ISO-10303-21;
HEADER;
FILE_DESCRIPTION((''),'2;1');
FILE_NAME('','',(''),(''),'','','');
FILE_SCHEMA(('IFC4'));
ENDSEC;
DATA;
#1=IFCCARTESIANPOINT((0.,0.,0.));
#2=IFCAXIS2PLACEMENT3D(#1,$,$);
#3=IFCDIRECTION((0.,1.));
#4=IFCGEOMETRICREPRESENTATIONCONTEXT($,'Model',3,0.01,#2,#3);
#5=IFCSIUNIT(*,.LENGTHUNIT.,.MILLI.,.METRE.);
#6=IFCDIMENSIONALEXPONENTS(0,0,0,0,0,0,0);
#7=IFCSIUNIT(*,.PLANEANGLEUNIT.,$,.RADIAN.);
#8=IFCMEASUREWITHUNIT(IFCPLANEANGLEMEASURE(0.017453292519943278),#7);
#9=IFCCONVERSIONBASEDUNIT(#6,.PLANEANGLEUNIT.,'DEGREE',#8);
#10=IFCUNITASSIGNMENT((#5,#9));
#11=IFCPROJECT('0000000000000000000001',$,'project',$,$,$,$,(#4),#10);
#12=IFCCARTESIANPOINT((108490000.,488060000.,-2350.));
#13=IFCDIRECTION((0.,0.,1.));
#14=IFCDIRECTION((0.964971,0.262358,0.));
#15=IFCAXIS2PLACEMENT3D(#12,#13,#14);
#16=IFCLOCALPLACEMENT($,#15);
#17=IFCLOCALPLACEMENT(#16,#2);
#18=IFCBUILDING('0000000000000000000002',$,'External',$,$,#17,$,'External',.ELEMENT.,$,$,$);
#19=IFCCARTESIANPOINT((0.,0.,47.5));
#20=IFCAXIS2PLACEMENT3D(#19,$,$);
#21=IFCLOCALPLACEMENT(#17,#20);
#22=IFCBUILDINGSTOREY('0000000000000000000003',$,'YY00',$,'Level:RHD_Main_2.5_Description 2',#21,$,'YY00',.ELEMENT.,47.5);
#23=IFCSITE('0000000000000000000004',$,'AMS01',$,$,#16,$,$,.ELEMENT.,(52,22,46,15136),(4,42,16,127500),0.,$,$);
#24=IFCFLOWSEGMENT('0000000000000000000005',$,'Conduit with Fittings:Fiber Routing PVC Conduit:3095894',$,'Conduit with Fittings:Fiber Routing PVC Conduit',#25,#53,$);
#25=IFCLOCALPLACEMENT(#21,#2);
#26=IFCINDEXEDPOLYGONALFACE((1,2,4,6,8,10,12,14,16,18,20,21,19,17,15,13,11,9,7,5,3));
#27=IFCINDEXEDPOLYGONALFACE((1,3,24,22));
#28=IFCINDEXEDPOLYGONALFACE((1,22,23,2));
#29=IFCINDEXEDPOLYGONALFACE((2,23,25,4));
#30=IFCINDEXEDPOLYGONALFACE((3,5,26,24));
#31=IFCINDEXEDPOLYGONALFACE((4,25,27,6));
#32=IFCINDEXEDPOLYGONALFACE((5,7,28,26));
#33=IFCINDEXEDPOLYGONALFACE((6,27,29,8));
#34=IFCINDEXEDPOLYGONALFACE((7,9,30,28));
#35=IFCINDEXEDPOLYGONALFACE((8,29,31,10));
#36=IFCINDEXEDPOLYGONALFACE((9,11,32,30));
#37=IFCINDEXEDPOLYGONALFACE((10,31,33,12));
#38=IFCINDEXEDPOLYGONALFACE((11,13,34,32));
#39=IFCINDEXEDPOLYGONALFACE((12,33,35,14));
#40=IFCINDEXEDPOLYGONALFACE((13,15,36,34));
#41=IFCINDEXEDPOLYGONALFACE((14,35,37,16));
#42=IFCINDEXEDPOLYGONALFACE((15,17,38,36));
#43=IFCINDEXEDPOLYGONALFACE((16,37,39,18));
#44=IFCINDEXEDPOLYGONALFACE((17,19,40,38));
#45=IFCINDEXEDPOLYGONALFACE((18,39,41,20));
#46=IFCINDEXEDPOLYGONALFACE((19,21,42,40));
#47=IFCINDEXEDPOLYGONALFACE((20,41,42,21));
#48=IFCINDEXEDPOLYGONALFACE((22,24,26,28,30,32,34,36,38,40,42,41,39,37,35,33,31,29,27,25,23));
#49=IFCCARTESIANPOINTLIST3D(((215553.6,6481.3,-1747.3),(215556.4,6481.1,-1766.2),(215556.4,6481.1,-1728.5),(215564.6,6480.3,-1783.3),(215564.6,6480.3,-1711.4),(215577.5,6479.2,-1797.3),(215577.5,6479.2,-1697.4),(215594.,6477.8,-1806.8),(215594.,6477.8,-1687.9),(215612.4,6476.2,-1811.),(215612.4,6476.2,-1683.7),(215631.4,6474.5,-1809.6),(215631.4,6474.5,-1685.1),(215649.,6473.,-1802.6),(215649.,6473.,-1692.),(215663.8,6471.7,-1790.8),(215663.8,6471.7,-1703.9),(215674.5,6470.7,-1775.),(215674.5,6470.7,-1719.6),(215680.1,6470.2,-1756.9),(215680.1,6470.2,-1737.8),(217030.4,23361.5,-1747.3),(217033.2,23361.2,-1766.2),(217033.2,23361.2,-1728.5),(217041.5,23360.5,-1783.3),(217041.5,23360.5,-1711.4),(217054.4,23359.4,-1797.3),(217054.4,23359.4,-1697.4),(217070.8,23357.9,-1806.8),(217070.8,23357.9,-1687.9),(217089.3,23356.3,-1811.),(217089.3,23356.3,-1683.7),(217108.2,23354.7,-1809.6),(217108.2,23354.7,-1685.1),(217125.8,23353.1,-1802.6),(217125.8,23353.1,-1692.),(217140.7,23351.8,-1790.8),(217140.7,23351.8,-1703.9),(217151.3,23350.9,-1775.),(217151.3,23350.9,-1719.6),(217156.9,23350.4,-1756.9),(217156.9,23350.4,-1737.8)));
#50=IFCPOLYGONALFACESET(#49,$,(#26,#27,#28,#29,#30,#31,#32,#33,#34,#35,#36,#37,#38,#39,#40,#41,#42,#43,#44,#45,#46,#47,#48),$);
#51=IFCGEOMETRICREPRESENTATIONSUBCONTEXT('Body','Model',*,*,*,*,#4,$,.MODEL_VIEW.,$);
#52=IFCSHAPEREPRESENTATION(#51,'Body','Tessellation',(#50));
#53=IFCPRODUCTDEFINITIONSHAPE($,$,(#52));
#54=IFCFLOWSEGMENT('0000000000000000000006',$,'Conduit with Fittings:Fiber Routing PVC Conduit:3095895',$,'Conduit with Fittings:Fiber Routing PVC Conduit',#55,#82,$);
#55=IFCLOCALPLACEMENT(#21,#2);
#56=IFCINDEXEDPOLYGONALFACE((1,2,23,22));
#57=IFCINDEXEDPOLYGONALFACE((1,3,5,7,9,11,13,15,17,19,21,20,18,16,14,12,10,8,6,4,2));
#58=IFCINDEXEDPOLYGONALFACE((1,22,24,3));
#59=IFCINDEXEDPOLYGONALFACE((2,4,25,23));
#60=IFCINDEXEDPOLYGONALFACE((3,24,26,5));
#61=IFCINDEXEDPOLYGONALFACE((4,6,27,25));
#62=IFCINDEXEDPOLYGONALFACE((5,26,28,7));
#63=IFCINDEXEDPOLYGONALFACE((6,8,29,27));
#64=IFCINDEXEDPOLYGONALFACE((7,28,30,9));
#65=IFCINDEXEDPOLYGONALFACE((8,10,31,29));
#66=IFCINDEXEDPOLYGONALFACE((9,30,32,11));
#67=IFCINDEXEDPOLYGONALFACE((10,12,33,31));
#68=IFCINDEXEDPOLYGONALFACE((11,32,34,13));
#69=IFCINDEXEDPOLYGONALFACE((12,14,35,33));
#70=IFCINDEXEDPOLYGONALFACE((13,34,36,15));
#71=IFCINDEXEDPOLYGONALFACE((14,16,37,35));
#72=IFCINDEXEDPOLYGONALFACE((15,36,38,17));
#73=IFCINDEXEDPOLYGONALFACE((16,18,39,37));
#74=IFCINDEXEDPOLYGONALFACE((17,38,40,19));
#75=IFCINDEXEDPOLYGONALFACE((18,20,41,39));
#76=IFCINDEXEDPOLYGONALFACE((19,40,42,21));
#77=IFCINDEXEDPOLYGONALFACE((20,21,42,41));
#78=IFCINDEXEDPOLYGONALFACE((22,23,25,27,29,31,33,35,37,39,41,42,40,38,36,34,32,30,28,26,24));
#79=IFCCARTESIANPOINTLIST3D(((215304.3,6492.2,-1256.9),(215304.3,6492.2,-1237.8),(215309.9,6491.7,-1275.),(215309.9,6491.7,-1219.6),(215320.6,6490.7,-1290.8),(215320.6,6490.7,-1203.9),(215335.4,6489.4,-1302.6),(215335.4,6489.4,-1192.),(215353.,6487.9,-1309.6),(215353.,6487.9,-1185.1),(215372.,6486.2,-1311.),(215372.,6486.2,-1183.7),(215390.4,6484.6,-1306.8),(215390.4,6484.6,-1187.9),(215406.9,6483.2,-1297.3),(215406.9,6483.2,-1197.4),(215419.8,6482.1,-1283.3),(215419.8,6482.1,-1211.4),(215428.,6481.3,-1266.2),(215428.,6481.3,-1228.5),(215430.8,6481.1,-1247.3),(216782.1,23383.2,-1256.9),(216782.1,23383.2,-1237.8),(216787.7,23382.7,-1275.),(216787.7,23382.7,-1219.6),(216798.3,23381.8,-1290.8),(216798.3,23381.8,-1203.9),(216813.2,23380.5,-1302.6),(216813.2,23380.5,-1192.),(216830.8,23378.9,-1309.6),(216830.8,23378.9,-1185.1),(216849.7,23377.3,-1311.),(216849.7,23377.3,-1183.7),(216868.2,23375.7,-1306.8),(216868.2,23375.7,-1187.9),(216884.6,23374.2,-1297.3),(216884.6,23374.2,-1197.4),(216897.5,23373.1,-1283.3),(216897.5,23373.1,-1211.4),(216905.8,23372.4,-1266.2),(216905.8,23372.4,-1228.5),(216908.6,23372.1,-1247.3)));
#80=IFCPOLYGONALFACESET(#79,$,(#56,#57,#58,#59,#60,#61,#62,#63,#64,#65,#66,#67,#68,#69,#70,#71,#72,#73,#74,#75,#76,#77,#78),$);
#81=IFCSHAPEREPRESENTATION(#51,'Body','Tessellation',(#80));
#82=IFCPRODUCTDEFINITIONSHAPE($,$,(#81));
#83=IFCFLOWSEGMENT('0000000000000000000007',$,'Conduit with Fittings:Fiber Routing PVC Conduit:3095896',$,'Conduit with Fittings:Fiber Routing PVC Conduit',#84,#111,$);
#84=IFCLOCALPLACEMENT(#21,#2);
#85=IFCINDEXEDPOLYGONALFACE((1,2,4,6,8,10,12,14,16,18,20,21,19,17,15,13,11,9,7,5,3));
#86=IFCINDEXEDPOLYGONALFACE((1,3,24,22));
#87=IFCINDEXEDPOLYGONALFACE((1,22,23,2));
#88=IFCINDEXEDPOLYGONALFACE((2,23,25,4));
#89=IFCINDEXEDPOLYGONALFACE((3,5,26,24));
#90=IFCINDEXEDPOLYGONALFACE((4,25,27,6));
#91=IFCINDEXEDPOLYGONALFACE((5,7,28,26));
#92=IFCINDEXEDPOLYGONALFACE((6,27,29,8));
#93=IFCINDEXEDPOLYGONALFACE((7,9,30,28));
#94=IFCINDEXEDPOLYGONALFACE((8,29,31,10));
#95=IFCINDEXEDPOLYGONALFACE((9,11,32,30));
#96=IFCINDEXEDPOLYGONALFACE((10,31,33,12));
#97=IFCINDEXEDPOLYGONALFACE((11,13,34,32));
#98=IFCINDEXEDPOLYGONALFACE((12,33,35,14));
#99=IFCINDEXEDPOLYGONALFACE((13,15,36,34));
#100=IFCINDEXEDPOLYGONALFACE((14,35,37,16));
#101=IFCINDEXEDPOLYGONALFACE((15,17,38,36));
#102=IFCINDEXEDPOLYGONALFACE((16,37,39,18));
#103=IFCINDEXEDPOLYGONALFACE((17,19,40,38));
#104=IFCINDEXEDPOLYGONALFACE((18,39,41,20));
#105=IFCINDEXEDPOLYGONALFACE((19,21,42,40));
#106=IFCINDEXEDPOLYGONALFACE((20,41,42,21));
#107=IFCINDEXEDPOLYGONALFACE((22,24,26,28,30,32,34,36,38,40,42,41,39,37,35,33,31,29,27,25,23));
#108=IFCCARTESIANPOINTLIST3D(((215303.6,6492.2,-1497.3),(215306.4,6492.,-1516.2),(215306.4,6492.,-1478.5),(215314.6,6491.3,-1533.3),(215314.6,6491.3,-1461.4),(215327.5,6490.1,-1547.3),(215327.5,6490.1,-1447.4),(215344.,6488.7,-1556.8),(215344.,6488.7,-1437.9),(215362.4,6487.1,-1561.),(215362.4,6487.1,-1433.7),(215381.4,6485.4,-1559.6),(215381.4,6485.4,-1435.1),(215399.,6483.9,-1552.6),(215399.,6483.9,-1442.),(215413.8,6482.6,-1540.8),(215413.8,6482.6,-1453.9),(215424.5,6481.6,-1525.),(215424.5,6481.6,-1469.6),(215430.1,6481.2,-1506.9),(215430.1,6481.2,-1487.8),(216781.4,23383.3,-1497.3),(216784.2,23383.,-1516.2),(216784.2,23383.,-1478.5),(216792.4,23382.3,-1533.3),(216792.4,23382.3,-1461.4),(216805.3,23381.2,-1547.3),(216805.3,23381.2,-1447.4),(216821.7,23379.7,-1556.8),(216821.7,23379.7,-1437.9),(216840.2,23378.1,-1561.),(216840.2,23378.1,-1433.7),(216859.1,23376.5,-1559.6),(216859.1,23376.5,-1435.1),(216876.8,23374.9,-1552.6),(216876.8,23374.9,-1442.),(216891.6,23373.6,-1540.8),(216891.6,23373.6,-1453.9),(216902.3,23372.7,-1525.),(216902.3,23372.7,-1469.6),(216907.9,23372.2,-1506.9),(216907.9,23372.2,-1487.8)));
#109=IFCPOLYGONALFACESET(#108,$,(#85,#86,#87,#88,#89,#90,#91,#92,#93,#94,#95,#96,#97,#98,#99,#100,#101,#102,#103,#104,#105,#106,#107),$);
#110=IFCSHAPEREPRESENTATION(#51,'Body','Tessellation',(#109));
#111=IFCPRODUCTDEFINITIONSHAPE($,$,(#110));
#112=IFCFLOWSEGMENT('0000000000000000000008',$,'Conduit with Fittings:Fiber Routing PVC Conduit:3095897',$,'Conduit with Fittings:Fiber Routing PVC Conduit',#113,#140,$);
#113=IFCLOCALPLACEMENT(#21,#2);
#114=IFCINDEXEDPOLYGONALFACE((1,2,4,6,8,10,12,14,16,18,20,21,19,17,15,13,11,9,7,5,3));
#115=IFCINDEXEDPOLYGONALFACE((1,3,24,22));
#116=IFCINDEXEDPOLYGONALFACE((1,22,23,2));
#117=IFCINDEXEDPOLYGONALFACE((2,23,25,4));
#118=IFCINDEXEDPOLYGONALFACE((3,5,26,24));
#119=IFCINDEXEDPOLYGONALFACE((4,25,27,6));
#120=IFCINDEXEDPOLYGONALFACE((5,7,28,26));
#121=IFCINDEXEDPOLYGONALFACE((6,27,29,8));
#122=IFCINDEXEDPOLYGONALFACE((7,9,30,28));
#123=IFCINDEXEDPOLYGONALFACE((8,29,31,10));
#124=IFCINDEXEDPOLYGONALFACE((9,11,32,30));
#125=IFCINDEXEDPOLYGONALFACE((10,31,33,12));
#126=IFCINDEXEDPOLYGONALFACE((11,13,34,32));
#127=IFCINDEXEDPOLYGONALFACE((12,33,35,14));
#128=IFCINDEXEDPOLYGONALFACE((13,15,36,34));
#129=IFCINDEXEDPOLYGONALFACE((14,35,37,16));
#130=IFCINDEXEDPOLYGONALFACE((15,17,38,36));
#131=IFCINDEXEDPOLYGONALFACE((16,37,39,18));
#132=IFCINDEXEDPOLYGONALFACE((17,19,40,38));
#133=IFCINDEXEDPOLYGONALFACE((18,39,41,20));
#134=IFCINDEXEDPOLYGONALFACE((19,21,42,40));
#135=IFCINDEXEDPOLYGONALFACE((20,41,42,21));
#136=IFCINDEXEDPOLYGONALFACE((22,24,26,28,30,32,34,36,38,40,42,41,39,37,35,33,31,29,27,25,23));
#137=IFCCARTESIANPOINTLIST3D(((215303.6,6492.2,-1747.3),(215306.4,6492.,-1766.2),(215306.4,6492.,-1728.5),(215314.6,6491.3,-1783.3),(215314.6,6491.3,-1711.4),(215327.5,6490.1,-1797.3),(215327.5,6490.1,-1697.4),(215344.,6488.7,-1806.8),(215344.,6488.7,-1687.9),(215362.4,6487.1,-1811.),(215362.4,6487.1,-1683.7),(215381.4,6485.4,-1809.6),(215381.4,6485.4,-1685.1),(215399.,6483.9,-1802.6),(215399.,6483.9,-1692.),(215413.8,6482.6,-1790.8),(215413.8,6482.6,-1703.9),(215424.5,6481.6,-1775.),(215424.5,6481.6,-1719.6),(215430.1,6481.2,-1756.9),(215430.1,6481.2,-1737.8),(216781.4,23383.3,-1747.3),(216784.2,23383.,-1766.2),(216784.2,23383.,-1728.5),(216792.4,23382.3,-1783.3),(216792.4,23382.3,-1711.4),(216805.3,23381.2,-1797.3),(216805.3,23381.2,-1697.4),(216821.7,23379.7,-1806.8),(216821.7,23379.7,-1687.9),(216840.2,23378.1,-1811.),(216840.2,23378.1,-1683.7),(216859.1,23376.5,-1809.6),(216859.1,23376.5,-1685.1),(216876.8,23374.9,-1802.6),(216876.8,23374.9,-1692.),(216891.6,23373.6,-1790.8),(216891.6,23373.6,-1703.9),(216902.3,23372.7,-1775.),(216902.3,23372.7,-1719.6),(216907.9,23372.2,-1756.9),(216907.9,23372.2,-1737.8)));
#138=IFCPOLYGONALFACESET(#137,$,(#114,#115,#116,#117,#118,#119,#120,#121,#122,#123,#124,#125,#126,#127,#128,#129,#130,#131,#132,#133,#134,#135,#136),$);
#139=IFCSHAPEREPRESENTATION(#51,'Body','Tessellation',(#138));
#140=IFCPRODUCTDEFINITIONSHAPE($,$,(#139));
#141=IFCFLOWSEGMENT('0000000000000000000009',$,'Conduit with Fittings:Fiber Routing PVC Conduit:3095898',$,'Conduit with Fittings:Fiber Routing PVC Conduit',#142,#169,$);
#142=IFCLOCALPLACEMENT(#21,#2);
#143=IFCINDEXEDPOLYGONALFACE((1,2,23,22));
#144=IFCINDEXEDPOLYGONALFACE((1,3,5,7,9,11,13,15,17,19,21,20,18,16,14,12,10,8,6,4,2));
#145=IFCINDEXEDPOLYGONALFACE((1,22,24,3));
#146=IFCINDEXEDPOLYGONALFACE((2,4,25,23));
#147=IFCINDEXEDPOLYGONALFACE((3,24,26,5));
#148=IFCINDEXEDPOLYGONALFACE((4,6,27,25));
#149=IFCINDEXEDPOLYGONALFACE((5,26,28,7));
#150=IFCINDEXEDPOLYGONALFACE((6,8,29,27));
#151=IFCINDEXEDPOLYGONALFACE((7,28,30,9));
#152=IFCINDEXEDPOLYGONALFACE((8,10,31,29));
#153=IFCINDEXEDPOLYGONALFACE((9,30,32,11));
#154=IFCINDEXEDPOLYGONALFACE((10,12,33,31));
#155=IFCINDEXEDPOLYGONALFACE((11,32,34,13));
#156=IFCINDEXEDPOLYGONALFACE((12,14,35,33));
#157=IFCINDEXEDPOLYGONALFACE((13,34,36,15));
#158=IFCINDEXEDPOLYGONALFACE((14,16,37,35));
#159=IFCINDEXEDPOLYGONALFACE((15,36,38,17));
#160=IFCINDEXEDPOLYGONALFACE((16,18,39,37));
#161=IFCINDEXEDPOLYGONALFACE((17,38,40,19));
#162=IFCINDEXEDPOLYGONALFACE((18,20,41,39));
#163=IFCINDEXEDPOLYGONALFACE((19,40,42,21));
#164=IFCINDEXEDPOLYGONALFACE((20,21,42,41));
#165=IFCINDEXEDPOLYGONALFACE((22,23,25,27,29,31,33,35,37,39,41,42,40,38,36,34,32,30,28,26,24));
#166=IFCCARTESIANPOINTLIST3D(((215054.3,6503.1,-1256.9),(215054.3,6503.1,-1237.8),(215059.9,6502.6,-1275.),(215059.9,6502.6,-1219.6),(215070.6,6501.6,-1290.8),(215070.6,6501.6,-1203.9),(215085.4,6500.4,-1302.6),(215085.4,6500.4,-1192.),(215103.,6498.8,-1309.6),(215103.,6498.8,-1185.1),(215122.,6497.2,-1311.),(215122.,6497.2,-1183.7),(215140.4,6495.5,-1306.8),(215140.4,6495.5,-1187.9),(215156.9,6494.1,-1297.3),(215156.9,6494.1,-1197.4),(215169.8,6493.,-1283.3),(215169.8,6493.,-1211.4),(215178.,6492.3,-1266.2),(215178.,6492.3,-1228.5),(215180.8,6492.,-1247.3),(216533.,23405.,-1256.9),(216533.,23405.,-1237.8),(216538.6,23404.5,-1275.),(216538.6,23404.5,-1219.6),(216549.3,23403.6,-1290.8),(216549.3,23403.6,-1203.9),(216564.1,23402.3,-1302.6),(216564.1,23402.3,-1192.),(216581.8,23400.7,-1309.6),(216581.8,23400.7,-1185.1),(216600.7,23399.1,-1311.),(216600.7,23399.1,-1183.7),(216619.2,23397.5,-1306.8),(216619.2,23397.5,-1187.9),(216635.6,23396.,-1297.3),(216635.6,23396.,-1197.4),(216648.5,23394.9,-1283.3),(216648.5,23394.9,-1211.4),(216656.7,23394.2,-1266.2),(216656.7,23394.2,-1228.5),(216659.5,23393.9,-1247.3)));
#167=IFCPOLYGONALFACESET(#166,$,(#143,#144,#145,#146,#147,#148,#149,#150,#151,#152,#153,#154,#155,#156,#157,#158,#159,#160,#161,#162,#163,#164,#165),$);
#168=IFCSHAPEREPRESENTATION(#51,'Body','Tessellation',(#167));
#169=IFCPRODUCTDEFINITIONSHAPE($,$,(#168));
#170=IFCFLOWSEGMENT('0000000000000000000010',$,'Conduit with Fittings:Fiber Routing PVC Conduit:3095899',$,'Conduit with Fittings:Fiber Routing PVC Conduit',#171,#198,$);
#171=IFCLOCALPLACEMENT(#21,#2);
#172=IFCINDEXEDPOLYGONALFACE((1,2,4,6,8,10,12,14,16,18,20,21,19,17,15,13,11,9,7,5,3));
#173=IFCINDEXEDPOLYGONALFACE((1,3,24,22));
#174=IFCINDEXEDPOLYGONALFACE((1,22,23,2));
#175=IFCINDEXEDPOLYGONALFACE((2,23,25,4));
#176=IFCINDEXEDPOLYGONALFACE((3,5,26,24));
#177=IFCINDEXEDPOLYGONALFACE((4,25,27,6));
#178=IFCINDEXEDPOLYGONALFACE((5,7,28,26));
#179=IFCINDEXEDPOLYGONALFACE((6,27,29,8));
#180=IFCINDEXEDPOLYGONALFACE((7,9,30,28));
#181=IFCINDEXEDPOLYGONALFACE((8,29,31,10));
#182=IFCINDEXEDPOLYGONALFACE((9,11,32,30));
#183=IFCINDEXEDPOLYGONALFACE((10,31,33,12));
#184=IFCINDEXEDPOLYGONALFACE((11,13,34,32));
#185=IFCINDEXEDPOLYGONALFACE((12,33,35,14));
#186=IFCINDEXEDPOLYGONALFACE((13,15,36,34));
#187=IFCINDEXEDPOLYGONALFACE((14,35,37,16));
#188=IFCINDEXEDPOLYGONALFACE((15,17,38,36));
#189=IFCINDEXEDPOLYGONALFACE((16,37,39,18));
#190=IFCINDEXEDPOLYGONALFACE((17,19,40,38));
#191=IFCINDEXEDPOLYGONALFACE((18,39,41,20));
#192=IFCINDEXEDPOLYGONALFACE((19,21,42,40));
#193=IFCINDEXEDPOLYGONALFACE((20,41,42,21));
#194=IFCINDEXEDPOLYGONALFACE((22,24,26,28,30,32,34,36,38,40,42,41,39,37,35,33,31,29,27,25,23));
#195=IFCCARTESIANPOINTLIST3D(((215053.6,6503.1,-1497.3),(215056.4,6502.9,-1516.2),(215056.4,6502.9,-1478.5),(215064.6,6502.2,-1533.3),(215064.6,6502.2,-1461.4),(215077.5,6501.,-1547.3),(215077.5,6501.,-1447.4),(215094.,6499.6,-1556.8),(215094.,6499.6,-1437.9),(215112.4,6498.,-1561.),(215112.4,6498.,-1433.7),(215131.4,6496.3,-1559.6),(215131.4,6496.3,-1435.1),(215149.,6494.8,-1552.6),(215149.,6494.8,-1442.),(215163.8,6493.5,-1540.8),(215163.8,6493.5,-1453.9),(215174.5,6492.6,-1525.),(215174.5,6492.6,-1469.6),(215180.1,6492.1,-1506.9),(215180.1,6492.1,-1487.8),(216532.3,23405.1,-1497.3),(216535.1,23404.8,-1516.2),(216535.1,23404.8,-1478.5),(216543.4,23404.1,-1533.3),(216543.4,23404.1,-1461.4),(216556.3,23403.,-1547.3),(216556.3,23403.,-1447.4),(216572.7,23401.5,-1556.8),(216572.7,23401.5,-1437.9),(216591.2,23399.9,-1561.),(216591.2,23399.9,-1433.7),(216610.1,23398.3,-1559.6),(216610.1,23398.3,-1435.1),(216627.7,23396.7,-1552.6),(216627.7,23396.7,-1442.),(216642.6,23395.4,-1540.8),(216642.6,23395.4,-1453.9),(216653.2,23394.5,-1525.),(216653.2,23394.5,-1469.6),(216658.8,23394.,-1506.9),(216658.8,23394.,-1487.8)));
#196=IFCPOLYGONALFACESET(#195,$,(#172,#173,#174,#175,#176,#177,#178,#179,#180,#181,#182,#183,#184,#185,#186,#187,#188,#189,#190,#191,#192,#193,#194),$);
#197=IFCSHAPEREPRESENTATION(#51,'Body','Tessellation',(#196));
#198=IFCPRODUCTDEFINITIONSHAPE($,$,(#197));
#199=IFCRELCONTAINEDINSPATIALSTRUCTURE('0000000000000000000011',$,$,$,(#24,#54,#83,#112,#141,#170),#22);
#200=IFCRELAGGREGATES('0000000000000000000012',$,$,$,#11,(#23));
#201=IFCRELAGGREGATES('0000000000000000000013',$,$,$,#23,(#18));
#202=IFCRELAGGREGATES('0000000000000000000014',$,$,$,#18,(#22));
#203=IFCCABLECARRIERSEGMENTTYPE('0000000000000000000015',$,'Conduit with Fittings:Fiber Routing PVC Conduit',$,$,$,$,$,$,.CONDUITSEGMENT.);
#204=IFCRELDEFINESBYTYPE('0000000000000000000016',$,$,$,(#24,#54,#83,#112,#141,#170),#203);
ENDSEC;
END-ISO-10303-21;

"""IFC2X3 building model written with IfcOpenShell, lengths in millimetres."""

from ifc_helpers import new_model, entity, si_unit, converted_unit, direction, frame, frame_2d, origin, origin_2d_with_axis, place, context, subcontext, project, spatial, circle, extrude, type_object, element, save


model = new_model("IFC2X3")

# Units and contexts
model_context = context("Model", 3, precision=0.01, world=origin(), true_north=direction((0.0, 1.0)))
body_context = subcontext(model_context, "Body", "Model", "MODEL_VIEW")
ifc_project = project(units=[si_unit("LENGTHUNIT", "METRE", prefix="MILLI"), converted_unit("PLANEANGLEUNIT", "DEGREE", entity("IfcPlaneAngleMeasure", 0.017453292519943278), si_unit("PLANEANGLEUNIT", "RADIAN"), dimensions=[0, 0, 0, 0, 0, 0, 0])], contexts=[model_context])

# Site, building, storey
site_placement = place(None, frame((108490000.0, 488060000.0, -2350.0), z_axis=(0.0, 0.0, 1.0), x_axis=(0.964971, 0.262358, 0.0)))
site = spatial("IfcSite", under=ifc_project, at=site_placement, Name="AMS01", CompositionType="ELEMENT", RefLatitude=(52, 22, 46, 15136), RefLongitude=(4, 42, 16, 127500), RefElevation=0.0)
building_placement = place(site_placement, origin())
building = spatial("IfcBuilding", under=site, at=building_placement, Name="External", LongName="External", CompositionType="ELEMENT")
storey_placement = place(building_placement, frame((0.0, 0.0, 47.5)))
storey = spatial("IfcBuildingStorey", under=building, at=storey_placement, Name="YY00", ObjectType="Level:RHD_Main_2.5_Description 2", LongName="YY00", CompositionType="ELEMENT", Elevation=47.5)

# Flow segments
cable_carrier_segment_type = type_object("IfcCableCarrierSegmentType", Name="Conduit with Fittings:Fiber Routing PVC Conduit", PredefinedType="CONDUITSEGMENT")
flow_segment_1_placement = place(storey_placement, origin())
element("IfcFlowSegment", 1, at=flow_segment_1_placement, inside=storey, type_object=cable_carrier_segment_type, Name="Conduit with Fittings:Fiber Routing PVC Conduit:3095894", ObjectType="Conduit with Fittings:Fiber Routing PVC Conduit", context=body_context, shape_type="SweptSolid", body=[
    extrude(circle(Radius=63.9, at=frame_2d((0.0, 0.0), x_axis=(1.0, 0.0))), frame((215617.2, 6475.7, -1747.3), z_axis=(0.087156, 0.996195, 0.0), x_axis=(-0.996195, 0.087156, 0.0)), (0.0, 0.0, 1.0), 16944.7),
])
flow_segment_2_placement = place(storey_placement, origin())
element("IfcFlowSegment", 2, at=flow_segment_2_placement, inside=storey, type_object=cable_carrier_segment_type, Name="Conduit with Fittings:Fiber Routing PVC Conduit:3095895", ObjectType="Conduit with Fittings:Fiber Routing PVC Conduit", context=body_context, shape_type="SweptSolid", body=[
    extrude(circle(Radius=63.9, at=frame_2d((0.0, 0.0), x_axis=(1.0, 0.0))), frame((215367.2, 6486.7, -1247.3), z_axis=(0.087156, 0.996195, 0.0), x_axis=(0.996195, -0.087156, 0.0)), (0.0, 0.0, 1.0), 16955.6),
])
flow_segment_3_placement = place(storey_placement, origin())
element("IfcFlowSegment", 3, at=flow_segment_3_placement, inside=storey, type_object=cable_carrier_segment_type, Name="Conduit with Fittings:Fiber Routing PVC Conduit:3095896", ObjectType="Conduit with Fittings:Fiber Routing PVC Conduit", context=body_context, shape_type="SweptSolid", body=[
    extrude(circle(Radius=63.9, at=frame_2d((0.0, 0.0), x_axis=(1.0, 0.0))), frame((215367.2, 6486.7, -1497.3), z_axis=(0.087156, 0.996195, 0.0), x_axis=(-0.996195, 0.087156, 0.0)), (0.0, 0.0, 1.0), 16955.6),
])
flow_segment_4_placement = place(storey_placement, origin())
element("IfcFlowSegment", 4, at=flow_segment_4_placement, inside=storey, type_object=cable_carrier_segment_type, Name="Conduit with Fittings:Fiber Routing PVC Conduit:3095897", ObjectType="Conduit with Fittings:Fiber Routing PVC Conduit", context=body_context, shape_type="SweptSolid", body=[
    extrude(circle(Radius=63.9, at=frame_2d((0.0, 0.0), x_axis=(1.0, 0.0))), frame((215367.2, 6486.7, -1747.3), z_axis=(0.087156, 0.996195, 0.0), x_axis=(-0.996195, 0.087156, 0.0)), (0.0, 0.0, 1.0), 16955.6),
])
flow_segment_5_placement = place(storey_placement, origin())
element("IfcFlowSegment", 5, at=flow_segment_5_placement, inside=storey, type_object=cable_carrier_segment_type, Name="Conduit with Fittings:Fiber Routing PVC Conduit:3095898", ObjectType="Conduit with Fittings:Fiber Routing PVC Conduit", context=body_context, shape_type="SweptSolid", body=[
    extrude(circle(Radius=63.9, at=origin_2d_with_axis()), frame((215117.2, 6497.6, -1247.3), z_axis=(0.087156, 0.996195, 0.0), x_axis=(0.996195, -0.087156, 0.0)), (0.0, 0.0, 1.0), 16966.5),
])
flow_segment_6_placement = place(storey_placement, origin())
element("IfcFlowSegment", 6, at=flow_segment_6_placement, inside=storey, type_object=cable_carrier_segment_type, Name="Conduit with Fittings:Fiber Routing PVC Conduit:3095899", ObjectType="Conduit with Fittings:Fiber Routing PVC Conduit", context=body_context, shape_type="SweptSolid", body=[
    extrude(circle(Radius=63.9, at=frame_2d((0.0, 0.0), x_axis=(1.0, 0.0))), frame((215117.2, 6497.6, -1497.3), z_axis=(0.087156, 0.996195, 0.0), x_axis=(-0.996195, 0.087156, 0.0)), (0.0, 0.0, 1.0), 16966.5),
])

save(model, "model.ifc")
